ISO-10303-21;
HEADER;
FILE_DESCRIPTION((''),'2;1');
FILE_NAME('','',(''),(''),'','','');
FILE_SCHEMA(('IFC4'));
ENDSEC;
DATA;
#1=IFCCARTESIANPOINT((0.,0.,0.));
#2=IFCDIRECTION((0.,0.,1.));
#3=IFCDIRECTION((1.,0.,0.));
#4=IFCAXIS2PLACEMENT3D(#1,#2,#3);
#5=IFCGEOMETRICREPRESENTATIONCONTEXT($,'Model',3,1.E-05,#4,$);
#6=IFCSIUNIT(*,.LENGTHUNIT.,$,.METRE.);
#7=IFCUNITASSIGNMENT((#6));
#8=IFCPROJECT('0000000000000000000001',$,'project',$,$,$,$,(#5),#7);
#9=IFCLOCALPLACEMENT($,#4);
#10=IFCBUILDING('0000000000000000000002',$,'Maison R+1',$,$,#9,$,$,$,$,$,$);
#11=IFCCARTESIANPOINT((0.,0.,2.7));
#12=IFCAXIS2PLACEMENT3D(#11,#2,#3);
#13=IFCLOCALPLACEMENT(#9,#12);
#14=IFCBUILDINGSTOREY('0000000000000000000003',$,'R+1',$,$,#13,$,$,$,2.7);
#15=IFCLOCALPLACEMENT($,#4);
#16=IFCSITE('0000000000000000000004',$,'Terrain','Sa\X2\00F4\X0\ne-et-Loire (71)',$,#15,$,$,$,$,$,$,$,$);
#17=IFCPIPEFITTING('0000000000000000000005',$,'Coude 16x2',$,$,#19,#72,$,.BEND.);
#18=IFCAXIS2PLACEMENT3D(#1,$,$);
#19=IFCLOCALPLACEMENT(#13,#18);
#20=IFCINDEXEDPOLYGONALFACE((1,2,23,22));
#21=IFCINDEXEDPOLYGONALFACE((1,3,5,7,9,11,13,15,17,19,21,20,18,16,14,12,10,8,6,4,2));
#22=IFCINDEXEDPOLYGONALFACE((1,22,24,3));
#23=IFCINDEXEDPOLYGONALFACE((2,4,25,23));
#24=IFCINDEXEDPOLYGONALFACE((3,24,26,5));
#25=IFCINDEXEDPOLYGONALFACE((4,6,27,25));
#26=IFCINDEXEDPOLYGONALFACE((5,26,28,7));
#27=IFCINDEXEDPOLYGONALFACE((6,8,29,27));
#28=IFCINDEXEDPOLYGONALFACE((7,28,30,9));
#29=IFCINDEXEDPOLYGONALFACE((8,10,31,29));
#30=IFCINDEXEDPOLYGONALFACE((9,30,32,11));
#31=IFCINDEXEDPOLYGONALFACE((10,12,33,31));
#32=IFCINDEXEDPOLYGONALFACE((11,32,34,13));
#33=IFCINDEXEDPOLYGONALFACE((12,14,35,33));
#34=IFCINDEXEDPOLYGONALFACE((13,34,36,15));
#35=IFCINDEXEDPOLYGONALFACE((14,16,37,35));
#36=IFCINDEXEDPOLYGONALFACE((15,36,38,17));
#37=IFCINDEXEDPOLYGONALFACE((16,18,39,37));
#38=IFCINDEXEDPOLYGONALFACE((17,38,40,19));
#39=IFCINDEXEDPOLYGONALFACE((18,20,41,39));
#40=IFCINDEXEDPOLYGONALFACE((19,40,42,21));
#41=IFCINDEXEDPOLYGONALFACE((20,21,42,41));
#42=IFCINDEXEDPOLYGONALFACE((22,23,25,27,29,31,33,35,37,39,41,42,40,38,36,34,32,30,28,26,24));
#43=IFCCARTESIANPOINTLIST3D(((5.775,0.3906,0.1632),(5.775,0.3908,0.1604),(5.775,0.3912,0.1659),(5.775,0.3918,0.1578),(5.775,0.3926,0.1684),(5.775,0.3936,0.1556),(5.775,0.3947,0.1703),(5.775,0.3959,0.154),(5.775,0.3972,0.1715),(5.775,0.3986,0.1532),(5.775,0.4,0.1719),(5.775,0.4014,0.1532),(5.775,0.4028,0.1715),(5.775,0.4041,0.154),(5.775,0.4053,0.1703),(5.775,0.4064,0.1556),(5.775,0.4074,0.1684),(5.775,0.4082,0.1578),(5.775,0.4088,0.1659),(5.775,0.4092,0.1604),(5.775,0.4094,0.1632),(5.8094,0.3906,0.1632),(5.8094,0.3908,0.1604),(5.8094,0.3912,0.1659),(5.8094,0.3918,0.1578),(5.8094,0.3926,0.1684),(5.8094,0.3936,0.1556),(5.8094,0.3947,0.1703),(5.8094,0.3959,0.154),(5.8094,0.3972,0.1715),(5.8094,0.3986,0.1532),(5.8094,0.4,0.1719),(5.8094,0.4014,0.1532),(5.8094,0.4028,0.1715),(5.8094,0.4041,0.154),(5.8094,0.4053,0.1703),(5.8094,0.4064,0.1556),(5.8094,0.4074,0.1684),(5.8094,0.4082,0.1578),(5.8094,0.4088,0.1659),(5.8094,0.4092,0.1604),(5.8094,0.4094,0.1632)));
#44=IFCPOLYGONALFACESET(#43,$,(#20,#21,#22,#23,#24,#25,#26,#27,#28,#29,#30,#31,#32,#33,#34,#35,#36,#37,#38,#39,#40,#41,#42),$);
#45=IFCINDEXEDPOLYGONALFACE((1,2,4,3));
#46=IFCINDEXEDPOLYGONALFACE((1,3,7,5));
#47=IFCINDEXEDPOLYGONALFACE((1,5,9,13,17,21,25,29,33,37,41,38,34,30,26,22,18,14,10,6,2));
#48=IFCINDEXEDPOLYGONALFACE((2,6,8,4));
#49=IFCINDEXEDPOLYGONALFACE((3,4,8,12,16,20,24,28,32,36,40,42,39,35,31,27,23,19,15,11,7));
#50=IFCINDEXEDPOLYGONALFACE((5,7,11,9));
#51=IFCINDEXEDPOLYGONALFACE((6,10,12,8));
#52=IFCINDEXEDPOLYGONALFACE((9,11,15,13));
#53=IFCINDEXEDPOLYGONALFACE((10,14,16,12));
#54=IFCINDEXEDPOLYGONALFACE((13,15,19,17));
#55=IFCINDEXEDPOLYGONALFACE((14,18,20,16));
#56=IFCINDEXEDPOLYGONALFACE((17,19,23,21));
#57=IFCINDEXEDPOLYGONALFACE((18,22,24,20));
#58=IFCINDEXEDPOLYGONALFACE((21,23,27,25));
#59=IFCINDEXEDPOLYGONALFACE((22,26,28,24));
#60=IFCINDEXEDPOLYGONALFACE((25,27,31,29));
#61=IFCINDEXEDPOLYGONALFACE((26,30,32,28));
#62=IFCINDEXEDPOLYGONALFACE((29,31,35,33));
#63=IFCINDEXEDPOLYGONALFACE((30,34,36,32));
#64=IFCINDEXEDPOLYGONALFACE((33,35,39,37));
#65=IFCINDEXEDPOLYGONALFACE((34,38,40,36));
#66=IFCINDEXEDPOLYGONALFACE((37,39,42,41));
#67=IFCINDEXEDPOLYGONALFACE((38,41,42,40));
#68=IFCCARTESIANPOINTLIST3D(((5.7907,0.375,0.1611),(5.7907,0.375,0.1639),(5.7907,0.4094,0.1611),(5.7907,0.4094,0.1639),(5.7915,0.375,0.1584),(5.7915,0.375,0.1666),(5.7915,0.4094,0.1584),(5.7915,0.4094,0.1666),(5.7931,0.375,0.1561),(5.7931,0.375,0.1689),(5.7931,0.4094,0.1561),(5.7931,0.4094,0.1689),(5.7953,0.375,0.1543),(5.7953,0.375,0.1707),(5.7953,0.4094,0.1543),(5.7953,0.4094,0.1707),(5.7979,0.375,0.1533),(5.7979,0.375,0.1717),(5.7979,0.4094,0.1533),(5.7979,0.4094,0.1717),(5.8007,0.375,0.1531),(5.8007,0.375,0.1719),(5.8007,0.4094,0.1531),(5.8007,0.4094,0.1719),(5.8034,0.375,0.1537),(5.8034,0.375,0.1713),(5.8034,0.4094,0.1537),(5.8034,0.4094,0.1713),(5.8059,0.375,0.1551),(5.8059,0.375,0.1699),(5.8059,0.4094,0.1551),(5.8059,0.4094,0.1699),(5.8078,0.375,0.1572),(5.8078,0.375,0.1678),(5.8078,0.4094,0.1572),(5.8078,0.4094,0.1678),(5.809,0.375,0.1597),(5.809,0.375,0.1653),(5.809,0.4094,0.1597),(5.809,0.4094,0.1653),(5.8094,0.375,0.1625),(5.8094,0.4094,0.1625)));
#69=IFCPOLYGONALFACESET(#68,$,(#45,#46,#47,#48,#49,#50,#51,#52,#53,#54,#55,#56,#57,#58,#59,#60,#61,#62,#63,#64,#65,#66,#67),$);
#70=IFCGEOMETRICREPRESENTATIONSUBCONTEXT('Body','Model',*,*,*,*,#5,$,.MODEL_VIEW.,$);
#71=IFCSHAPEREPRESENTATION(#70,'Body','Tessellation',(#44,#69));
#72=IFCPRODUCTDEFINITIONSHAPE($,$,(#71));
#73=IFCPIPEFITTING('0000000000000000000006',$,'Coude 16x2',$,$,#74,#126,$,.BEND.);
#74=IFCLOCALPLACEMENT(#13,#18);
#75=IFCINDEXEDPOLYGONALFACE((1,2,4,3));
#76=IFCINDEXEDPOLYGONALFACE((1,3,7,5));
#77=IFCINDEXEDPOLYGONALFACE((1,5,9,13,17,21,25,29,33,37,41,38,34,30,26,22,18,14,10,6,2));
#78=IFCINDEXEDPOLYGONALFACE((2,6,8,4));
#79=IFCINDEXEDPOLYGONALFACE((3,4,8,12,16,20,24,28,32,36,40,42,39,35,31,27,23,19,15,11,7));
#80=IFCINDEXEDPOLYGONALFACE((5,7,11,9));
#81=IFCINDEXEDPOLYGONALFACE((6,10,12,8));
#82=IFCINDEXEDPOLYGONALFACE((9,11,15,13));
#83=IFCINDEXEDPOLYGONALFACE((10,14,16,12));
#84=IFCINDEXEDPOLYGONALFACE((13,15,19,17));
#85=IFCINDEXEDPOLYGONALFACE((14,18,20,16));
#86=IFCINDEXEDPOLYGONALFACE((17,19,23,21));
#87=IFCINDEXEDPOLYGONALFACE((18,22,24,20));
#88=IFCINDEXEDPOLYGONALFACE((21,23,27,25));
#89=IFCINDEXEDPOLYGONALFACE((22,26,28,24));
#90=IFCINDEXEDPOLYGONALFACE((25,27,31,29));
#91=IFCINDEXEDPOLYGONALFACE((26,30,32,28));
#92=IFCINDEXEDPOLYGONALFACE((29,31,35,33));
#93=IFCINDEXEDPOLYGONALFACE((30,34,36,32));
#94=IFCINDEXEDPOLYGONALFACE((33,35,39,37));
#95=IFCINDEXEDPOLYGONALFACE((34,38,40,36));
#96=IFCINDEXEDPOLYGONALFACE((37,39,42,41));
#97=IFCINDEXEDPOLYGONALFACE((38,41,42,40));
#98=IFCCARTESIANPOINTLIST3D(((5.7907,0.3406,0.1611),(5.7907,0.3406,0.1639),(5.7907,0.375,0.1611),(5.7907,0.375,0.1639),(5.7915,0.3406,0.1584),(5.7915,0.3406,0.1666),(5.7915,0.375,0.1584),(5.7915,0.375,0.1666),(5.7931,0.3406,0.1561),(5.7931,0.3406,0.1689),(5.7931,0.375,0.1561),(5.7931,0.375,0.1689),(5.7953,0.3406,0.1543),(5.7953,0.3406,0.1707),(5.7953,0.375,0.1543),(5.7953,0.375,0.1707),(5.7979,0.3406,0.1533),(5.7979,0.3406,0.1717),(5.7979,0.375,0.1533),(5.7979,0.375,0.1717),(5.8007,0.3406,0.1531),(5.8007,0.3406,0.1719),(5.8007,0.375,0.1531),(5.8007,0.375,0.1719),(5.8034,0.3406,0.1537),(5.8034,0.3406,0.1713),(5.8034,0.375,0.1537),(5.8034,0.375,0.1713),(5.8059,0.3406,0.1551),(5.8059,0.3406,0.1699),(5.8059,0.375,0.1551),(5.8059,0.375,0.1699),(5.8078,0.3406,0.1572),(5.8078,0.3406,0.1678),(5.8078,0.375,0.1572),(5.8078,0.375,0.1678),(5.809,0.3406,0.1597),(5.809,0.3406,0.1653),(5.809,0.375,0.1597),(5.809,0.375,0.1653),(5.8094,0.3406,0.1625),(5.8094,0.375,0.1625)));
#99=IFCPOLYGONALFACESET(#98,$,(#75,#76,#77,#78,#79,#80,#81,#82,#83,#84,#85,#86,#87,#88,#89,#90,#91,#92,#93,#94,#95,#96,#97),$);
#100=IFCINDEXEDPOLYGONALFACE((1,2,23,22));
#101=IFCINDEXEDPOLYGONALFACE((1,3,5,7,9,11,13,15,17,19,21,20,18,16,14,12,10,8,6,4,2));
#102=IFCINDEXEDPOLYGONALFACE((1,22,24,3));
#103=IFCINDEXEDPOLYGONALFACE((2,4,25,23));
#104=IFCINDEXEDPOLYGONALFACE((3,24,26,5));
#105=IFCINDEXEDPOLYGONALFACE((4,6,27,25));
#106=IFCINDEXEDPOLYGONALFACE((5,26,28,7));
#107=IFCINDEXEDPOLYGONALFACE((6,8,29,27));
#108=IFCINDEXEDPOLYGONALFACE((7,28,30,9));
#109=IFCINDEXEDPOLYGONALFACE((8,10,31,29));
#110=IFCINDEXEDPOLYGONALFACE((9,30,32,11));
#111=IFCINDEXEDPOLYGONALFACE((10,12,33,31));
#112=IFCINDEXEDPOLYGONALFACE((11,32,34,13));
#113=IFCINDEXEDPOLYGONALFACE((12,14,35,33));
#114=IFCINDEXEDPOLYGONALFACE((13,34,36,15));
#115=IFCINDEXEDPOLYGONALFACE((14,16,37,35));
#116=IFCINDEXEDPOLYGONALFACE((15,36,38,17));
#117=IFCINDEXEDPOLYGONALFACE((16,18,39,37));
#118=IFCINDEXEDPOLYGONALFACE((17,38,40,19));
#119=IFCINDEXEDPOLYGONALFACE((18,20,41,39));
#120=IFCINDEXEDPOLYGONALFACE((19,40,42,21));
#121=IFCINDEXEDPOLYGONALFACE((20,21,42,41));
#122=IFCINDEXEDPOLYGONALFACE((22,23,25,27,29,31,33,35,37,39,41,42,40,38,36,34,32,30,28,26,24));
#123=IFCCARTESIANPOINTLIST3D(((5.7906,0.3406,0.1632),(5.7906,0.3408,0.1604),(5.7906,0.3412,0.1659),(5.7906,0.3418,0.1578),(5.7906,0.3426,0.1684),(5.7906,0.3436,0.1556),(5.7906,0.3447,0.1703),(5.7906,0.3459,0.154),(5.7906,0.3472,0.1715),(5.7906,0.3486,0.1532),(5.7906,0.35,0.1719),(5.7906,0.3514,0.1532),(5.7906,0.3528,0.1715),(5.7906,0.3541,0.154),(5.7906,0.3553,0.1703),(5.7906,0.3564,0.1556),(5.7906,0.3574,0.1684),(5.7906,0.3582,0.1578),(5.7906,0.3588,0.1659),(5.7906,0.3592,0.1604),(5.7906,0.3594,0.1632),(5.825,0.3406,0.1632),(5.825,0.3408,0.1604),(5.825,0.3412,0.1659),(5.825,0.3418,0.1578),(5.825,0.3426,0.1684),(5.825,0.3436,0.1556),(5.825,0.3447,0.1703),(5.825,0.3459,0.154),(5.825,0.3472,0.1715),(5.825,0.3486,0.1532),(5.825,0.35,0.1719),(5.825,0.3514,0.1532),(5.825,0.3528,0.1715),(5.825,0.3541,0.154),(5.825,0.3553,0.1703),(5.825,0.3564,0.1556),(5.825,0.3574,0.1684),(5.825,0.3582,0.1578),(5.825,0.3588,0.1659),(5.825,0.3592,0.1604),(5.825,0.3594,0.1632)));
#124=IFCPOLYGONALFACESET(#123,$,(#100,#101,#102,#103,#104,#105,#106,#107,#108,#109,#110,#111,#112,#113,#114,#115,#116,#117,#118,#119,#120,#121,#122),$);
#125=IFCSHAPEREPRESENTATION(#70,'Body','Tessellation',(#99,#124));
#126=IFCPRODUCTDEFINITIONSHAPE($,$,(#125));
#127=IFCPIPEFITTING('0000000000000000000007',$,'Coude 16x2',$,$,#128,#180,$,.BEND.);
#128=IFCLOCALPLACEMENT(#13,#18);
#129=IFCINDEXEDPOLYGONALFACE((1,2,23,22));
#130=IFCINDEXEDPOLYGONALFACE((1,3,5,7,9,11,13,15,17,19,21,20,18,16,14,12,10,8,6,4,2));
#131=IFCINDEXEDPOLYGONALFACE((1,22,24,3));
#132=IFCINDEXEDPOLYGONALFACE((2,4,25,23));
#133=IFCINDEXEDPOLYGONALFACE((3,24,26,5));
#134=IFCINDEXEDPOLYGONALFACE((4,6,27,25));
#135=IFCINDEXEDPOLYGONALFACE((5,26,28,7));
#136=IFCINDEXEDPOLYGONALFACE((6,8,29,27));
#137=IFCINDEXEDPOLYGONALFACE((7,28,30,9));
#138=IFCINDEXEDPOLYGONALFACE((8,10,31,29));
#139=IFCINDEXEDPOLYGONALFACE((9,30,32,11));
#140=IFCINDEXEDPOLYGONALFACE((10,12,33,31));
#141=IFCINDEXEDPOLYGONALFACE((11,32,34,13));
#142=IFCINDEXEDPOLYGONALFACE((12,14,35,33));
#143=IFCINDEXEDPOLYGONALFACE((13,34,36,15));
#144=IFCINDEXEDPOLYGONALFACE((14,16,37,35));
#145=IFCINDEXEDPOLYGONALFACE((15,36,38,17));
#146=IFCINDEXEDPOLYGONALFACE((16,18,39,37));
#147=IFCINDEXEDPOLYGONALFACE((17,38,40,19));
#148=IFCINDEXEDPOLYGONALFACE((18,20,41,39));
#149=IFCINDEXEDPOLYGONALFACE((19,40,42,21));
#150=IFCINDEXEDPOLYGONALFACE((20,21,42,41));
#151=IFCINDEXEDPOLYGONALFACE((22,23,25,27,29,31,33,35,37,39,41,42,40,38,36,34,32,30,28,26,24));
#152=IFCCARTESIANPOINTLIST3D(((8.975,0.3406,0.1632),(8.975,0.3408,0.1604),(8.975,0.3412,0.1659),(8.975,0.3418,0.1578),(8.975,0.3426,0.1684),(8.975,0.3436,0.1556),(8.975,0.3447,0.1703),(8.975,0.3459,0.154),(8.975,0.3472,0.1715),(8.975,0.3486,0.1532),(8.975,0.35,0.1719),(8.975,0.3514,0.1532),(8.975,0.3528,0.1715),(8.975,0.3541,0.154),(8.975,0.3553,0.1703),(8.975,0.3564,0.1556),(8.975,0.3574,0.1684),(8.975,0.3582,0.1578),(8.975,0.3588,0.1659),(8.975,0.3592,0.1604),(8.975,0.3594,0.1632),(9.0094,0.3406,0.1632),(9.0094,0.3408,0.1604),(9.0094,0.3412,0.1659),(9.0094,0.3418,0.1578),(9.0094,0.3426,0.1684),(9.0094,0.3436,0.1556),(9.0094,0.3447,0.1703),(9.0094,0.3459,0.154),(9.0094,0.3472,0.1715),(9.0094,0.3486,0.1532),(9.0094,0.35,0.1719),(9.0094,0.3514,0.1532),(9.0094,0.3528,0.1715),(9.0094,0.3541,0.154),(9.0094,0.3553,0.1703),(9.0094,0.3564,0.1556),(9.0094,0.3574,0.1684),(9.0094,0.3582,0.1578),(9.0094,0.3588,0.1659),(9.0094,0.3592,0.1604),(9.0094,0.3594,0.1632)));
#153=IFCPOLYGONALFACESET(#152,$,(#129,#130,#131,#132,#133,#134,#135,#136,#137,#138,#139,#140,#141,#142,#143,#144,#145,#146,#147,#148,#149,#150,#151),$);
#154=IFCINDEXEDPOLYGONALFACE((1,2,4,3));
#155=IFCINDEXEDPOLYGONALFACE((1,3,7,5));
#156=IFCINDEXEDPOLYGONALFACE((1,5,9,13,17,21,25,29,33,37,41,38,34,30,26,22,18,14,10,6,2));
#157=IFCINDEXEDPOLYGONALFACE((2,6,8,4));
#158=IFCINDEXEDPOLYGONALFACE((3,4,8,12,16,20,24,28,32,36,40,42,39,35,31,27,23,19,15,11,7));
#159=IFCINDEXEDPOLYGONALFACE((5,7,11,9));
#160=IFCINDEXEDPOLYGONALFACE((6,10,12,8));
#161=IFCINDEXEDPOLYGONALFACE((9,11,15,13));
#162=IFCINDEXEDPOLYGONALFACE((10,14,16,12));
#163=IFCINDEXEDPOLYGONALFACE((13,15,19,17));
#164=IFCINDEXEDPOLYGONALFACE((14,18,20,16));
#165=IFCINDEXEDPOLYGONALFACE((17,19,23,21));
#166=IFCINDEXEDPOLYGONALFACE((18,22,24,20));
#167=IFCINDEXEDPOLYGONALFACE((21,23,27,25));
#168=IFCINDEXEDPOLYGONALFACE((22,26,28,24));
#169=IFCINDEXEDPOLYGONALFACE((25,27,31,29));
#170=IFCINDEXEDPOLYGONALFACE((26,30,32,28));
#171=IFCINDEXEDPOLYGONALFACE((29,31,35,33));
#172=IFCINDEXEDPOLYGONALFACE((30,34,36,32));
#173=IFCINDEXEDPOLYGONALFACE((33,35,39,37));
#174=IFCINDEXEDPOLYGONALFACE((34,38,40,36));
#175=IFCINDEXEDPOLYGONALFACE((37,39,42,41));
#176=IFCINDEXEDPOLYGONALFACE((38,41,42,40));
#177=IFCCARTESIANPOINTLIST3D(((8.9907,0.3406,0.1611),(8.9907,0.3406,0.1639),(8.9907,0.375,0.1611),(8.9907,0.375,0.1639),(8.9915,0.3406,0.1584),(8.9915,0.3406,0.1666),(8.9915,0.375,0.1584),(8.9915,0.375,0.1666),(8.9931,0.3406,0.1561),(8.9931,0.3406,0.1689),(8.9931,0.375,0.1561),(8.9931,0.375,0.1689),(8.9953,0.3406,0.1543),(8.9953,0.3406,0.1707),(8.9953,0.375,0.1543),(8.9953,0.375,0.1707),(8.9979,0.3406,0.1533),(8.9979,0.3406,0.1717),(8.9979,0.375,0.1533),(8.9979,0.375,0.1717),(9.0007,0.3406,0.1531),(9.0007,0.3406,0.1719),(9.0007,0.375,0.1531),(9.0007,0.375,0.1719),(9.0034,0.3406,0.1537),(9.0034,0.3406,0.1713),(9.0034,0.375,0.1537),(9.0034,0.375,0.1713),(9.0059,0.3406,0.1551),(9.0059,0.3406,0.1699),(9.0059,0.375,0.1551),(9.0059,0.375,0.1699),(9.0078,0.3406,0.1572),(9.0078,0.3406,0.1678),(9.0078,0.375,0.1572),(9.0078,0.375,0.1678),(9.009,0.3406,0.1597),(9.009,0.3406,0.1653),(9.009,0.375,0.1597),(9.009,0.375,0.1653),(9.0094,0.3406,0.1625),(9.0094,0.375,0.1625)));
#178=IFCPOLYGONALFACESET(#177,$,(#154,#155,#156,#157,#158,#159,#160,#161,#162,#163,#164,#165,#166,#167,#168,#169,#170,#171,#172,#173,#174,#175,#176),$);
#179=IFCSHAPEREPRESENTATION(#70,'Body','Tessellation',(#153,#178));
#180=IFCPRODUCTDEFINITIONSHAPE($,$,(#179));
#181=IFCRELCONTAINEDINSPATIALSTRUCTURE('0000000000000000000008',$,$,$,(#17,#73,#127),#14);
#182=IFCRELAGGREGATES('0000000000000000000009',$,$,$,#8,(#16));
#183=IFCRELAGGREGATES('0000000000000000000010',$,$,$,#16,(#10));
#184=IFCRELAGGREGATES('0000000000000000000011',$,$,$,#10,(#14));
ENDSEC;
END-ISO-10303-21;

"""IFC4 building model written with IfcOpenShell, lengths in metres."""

from ifc_helpers import new_model, si_unit, frame, origin_with_axes, place, context, subcontext, project, spatial, circle, extrude, element, save


model = new_model("IFC4")

# Units and contexts
model_context = context("Model", 3, precision=1e-05, world=origin_with_axes())
body_context = subcontext(model_context, "Body", "Model", "MODEL_VIEW")
ifc_project = project(units=[si_unit("LENGTHUNIT", "METRE")], contexts=[model_context])

# Site, building, storey
site_placement = place(None, origin_with_axes())
site = spatial("IfcSite", under=ifc_project, at=site_placement, Name="Terrain", Description="Saône-et-Loire (71)")
building_placement = place(None, origin_with_axes())
building = spatial("IfcBuilding", under=site, at=building_placement, Name="Maison R+1")
storey_placement = place(building_placement, frame((0.0, 0.0, 2.7), z_axis=(0.0, 0.0, 1.0), x_axis=(1.0, 0.0, 0.0)))
storey = spatial("IfcBuildingStorey", under=building, at=storey_placement, Name="R+1", Elevation=2.7)

# Pipe fittings
pipe_fitting_1_placement = place(storey_placement, frame((5.8, 0.4, 0.1625), z_axis=(0.0, 0.0, 1.0), x_axis=(1.0, 0.0, 0.0)))
element("IfcPipeFitting", 1, at=pipe_fitting_1_placement, inside=storey, Name="Coude 16x2", PredefinedType="BEND", context=body_context, shape_type="SweptSolid", body=[
    extrude(circle(Radius=0.0094), frame((0.0094, 0.0, 0.0), z_axis=(-1.0, 0.0, 0.0), x_axis=(0.0, 0.0, 1.0)), (0.0, 0.0, 1.0), 0.0344),
    extrude(circle(Radius=0.0094), frame((0.0, 0.0094, 0.0), z_axis=(0.0, -1.0, 0.0), x_axis=(1.0, 0.0, 0.0)), (0.0, 0.0, 1.0), 0.0344),
])
pipe_fitting_2_placement = place(storey_placement, frame((5.8, 0.35, 0.1625), z_axis=(0.0, 0.0, 1.0), x_axis=(1.0, 0.0, 0.0)))
element("IfcPipeFitting", 2, at=pipe_fitting_2_placement, inside=storey, Name="Coude 16x2", PredefinedType="BEND", context=body_context, shape_type="SweptSolid", body=[
    extrude(circle(Radius=0.0094), frame((0.0, -0.0094, 0.0), z_axis=(0.0, 1.0, 0.0), x_axis=(1.0, 0.0, 0.0)), (0.0, 0.0, 1.0), 0.0344),
    extrude(circle(Radius=0.0094), frame((-0.0094, 0.0, 0.0), z_axis=(1.0, 0.0, 0.0), x_axis=(0.0, 0.0, 1.0)), (0.0, 0.0, 1.0), 0.0344),
])
pipe_fitting_3_placement = place(storey_placement, frame((9.0, 0.35, 0.1625), z_axis=(0.0, 0.0, 1.0), x_axis=(1.0, 0.0, 0.0)))
element("IfcPipeFitting", 3, at=pipe_fitting_3_placement, inside=storey, Name="Coude 16x2", PredefinedType="BEND", context=body_context, shape_type="SweptSolid", body=[
    extrude(circle(Radius=0.0094), frame((0.0094, 0.0, 0.0), z_axis=(-1.0, 0.0, 0.0), x_axis=(0.0, 0.0, 1.0)), (0.0, 0.0, 1.0), 0.0344),
    extrude(circle(Radius=0.0094), frame((0.0, -0.0094, 0.0), z_axis=(0.0, 1.0, 0.0), x_axis=(1.0, 0.0, 0.0)), (0.0, 0.0, 1.0), 0.0344),
])

save(model, "model.ifc")
